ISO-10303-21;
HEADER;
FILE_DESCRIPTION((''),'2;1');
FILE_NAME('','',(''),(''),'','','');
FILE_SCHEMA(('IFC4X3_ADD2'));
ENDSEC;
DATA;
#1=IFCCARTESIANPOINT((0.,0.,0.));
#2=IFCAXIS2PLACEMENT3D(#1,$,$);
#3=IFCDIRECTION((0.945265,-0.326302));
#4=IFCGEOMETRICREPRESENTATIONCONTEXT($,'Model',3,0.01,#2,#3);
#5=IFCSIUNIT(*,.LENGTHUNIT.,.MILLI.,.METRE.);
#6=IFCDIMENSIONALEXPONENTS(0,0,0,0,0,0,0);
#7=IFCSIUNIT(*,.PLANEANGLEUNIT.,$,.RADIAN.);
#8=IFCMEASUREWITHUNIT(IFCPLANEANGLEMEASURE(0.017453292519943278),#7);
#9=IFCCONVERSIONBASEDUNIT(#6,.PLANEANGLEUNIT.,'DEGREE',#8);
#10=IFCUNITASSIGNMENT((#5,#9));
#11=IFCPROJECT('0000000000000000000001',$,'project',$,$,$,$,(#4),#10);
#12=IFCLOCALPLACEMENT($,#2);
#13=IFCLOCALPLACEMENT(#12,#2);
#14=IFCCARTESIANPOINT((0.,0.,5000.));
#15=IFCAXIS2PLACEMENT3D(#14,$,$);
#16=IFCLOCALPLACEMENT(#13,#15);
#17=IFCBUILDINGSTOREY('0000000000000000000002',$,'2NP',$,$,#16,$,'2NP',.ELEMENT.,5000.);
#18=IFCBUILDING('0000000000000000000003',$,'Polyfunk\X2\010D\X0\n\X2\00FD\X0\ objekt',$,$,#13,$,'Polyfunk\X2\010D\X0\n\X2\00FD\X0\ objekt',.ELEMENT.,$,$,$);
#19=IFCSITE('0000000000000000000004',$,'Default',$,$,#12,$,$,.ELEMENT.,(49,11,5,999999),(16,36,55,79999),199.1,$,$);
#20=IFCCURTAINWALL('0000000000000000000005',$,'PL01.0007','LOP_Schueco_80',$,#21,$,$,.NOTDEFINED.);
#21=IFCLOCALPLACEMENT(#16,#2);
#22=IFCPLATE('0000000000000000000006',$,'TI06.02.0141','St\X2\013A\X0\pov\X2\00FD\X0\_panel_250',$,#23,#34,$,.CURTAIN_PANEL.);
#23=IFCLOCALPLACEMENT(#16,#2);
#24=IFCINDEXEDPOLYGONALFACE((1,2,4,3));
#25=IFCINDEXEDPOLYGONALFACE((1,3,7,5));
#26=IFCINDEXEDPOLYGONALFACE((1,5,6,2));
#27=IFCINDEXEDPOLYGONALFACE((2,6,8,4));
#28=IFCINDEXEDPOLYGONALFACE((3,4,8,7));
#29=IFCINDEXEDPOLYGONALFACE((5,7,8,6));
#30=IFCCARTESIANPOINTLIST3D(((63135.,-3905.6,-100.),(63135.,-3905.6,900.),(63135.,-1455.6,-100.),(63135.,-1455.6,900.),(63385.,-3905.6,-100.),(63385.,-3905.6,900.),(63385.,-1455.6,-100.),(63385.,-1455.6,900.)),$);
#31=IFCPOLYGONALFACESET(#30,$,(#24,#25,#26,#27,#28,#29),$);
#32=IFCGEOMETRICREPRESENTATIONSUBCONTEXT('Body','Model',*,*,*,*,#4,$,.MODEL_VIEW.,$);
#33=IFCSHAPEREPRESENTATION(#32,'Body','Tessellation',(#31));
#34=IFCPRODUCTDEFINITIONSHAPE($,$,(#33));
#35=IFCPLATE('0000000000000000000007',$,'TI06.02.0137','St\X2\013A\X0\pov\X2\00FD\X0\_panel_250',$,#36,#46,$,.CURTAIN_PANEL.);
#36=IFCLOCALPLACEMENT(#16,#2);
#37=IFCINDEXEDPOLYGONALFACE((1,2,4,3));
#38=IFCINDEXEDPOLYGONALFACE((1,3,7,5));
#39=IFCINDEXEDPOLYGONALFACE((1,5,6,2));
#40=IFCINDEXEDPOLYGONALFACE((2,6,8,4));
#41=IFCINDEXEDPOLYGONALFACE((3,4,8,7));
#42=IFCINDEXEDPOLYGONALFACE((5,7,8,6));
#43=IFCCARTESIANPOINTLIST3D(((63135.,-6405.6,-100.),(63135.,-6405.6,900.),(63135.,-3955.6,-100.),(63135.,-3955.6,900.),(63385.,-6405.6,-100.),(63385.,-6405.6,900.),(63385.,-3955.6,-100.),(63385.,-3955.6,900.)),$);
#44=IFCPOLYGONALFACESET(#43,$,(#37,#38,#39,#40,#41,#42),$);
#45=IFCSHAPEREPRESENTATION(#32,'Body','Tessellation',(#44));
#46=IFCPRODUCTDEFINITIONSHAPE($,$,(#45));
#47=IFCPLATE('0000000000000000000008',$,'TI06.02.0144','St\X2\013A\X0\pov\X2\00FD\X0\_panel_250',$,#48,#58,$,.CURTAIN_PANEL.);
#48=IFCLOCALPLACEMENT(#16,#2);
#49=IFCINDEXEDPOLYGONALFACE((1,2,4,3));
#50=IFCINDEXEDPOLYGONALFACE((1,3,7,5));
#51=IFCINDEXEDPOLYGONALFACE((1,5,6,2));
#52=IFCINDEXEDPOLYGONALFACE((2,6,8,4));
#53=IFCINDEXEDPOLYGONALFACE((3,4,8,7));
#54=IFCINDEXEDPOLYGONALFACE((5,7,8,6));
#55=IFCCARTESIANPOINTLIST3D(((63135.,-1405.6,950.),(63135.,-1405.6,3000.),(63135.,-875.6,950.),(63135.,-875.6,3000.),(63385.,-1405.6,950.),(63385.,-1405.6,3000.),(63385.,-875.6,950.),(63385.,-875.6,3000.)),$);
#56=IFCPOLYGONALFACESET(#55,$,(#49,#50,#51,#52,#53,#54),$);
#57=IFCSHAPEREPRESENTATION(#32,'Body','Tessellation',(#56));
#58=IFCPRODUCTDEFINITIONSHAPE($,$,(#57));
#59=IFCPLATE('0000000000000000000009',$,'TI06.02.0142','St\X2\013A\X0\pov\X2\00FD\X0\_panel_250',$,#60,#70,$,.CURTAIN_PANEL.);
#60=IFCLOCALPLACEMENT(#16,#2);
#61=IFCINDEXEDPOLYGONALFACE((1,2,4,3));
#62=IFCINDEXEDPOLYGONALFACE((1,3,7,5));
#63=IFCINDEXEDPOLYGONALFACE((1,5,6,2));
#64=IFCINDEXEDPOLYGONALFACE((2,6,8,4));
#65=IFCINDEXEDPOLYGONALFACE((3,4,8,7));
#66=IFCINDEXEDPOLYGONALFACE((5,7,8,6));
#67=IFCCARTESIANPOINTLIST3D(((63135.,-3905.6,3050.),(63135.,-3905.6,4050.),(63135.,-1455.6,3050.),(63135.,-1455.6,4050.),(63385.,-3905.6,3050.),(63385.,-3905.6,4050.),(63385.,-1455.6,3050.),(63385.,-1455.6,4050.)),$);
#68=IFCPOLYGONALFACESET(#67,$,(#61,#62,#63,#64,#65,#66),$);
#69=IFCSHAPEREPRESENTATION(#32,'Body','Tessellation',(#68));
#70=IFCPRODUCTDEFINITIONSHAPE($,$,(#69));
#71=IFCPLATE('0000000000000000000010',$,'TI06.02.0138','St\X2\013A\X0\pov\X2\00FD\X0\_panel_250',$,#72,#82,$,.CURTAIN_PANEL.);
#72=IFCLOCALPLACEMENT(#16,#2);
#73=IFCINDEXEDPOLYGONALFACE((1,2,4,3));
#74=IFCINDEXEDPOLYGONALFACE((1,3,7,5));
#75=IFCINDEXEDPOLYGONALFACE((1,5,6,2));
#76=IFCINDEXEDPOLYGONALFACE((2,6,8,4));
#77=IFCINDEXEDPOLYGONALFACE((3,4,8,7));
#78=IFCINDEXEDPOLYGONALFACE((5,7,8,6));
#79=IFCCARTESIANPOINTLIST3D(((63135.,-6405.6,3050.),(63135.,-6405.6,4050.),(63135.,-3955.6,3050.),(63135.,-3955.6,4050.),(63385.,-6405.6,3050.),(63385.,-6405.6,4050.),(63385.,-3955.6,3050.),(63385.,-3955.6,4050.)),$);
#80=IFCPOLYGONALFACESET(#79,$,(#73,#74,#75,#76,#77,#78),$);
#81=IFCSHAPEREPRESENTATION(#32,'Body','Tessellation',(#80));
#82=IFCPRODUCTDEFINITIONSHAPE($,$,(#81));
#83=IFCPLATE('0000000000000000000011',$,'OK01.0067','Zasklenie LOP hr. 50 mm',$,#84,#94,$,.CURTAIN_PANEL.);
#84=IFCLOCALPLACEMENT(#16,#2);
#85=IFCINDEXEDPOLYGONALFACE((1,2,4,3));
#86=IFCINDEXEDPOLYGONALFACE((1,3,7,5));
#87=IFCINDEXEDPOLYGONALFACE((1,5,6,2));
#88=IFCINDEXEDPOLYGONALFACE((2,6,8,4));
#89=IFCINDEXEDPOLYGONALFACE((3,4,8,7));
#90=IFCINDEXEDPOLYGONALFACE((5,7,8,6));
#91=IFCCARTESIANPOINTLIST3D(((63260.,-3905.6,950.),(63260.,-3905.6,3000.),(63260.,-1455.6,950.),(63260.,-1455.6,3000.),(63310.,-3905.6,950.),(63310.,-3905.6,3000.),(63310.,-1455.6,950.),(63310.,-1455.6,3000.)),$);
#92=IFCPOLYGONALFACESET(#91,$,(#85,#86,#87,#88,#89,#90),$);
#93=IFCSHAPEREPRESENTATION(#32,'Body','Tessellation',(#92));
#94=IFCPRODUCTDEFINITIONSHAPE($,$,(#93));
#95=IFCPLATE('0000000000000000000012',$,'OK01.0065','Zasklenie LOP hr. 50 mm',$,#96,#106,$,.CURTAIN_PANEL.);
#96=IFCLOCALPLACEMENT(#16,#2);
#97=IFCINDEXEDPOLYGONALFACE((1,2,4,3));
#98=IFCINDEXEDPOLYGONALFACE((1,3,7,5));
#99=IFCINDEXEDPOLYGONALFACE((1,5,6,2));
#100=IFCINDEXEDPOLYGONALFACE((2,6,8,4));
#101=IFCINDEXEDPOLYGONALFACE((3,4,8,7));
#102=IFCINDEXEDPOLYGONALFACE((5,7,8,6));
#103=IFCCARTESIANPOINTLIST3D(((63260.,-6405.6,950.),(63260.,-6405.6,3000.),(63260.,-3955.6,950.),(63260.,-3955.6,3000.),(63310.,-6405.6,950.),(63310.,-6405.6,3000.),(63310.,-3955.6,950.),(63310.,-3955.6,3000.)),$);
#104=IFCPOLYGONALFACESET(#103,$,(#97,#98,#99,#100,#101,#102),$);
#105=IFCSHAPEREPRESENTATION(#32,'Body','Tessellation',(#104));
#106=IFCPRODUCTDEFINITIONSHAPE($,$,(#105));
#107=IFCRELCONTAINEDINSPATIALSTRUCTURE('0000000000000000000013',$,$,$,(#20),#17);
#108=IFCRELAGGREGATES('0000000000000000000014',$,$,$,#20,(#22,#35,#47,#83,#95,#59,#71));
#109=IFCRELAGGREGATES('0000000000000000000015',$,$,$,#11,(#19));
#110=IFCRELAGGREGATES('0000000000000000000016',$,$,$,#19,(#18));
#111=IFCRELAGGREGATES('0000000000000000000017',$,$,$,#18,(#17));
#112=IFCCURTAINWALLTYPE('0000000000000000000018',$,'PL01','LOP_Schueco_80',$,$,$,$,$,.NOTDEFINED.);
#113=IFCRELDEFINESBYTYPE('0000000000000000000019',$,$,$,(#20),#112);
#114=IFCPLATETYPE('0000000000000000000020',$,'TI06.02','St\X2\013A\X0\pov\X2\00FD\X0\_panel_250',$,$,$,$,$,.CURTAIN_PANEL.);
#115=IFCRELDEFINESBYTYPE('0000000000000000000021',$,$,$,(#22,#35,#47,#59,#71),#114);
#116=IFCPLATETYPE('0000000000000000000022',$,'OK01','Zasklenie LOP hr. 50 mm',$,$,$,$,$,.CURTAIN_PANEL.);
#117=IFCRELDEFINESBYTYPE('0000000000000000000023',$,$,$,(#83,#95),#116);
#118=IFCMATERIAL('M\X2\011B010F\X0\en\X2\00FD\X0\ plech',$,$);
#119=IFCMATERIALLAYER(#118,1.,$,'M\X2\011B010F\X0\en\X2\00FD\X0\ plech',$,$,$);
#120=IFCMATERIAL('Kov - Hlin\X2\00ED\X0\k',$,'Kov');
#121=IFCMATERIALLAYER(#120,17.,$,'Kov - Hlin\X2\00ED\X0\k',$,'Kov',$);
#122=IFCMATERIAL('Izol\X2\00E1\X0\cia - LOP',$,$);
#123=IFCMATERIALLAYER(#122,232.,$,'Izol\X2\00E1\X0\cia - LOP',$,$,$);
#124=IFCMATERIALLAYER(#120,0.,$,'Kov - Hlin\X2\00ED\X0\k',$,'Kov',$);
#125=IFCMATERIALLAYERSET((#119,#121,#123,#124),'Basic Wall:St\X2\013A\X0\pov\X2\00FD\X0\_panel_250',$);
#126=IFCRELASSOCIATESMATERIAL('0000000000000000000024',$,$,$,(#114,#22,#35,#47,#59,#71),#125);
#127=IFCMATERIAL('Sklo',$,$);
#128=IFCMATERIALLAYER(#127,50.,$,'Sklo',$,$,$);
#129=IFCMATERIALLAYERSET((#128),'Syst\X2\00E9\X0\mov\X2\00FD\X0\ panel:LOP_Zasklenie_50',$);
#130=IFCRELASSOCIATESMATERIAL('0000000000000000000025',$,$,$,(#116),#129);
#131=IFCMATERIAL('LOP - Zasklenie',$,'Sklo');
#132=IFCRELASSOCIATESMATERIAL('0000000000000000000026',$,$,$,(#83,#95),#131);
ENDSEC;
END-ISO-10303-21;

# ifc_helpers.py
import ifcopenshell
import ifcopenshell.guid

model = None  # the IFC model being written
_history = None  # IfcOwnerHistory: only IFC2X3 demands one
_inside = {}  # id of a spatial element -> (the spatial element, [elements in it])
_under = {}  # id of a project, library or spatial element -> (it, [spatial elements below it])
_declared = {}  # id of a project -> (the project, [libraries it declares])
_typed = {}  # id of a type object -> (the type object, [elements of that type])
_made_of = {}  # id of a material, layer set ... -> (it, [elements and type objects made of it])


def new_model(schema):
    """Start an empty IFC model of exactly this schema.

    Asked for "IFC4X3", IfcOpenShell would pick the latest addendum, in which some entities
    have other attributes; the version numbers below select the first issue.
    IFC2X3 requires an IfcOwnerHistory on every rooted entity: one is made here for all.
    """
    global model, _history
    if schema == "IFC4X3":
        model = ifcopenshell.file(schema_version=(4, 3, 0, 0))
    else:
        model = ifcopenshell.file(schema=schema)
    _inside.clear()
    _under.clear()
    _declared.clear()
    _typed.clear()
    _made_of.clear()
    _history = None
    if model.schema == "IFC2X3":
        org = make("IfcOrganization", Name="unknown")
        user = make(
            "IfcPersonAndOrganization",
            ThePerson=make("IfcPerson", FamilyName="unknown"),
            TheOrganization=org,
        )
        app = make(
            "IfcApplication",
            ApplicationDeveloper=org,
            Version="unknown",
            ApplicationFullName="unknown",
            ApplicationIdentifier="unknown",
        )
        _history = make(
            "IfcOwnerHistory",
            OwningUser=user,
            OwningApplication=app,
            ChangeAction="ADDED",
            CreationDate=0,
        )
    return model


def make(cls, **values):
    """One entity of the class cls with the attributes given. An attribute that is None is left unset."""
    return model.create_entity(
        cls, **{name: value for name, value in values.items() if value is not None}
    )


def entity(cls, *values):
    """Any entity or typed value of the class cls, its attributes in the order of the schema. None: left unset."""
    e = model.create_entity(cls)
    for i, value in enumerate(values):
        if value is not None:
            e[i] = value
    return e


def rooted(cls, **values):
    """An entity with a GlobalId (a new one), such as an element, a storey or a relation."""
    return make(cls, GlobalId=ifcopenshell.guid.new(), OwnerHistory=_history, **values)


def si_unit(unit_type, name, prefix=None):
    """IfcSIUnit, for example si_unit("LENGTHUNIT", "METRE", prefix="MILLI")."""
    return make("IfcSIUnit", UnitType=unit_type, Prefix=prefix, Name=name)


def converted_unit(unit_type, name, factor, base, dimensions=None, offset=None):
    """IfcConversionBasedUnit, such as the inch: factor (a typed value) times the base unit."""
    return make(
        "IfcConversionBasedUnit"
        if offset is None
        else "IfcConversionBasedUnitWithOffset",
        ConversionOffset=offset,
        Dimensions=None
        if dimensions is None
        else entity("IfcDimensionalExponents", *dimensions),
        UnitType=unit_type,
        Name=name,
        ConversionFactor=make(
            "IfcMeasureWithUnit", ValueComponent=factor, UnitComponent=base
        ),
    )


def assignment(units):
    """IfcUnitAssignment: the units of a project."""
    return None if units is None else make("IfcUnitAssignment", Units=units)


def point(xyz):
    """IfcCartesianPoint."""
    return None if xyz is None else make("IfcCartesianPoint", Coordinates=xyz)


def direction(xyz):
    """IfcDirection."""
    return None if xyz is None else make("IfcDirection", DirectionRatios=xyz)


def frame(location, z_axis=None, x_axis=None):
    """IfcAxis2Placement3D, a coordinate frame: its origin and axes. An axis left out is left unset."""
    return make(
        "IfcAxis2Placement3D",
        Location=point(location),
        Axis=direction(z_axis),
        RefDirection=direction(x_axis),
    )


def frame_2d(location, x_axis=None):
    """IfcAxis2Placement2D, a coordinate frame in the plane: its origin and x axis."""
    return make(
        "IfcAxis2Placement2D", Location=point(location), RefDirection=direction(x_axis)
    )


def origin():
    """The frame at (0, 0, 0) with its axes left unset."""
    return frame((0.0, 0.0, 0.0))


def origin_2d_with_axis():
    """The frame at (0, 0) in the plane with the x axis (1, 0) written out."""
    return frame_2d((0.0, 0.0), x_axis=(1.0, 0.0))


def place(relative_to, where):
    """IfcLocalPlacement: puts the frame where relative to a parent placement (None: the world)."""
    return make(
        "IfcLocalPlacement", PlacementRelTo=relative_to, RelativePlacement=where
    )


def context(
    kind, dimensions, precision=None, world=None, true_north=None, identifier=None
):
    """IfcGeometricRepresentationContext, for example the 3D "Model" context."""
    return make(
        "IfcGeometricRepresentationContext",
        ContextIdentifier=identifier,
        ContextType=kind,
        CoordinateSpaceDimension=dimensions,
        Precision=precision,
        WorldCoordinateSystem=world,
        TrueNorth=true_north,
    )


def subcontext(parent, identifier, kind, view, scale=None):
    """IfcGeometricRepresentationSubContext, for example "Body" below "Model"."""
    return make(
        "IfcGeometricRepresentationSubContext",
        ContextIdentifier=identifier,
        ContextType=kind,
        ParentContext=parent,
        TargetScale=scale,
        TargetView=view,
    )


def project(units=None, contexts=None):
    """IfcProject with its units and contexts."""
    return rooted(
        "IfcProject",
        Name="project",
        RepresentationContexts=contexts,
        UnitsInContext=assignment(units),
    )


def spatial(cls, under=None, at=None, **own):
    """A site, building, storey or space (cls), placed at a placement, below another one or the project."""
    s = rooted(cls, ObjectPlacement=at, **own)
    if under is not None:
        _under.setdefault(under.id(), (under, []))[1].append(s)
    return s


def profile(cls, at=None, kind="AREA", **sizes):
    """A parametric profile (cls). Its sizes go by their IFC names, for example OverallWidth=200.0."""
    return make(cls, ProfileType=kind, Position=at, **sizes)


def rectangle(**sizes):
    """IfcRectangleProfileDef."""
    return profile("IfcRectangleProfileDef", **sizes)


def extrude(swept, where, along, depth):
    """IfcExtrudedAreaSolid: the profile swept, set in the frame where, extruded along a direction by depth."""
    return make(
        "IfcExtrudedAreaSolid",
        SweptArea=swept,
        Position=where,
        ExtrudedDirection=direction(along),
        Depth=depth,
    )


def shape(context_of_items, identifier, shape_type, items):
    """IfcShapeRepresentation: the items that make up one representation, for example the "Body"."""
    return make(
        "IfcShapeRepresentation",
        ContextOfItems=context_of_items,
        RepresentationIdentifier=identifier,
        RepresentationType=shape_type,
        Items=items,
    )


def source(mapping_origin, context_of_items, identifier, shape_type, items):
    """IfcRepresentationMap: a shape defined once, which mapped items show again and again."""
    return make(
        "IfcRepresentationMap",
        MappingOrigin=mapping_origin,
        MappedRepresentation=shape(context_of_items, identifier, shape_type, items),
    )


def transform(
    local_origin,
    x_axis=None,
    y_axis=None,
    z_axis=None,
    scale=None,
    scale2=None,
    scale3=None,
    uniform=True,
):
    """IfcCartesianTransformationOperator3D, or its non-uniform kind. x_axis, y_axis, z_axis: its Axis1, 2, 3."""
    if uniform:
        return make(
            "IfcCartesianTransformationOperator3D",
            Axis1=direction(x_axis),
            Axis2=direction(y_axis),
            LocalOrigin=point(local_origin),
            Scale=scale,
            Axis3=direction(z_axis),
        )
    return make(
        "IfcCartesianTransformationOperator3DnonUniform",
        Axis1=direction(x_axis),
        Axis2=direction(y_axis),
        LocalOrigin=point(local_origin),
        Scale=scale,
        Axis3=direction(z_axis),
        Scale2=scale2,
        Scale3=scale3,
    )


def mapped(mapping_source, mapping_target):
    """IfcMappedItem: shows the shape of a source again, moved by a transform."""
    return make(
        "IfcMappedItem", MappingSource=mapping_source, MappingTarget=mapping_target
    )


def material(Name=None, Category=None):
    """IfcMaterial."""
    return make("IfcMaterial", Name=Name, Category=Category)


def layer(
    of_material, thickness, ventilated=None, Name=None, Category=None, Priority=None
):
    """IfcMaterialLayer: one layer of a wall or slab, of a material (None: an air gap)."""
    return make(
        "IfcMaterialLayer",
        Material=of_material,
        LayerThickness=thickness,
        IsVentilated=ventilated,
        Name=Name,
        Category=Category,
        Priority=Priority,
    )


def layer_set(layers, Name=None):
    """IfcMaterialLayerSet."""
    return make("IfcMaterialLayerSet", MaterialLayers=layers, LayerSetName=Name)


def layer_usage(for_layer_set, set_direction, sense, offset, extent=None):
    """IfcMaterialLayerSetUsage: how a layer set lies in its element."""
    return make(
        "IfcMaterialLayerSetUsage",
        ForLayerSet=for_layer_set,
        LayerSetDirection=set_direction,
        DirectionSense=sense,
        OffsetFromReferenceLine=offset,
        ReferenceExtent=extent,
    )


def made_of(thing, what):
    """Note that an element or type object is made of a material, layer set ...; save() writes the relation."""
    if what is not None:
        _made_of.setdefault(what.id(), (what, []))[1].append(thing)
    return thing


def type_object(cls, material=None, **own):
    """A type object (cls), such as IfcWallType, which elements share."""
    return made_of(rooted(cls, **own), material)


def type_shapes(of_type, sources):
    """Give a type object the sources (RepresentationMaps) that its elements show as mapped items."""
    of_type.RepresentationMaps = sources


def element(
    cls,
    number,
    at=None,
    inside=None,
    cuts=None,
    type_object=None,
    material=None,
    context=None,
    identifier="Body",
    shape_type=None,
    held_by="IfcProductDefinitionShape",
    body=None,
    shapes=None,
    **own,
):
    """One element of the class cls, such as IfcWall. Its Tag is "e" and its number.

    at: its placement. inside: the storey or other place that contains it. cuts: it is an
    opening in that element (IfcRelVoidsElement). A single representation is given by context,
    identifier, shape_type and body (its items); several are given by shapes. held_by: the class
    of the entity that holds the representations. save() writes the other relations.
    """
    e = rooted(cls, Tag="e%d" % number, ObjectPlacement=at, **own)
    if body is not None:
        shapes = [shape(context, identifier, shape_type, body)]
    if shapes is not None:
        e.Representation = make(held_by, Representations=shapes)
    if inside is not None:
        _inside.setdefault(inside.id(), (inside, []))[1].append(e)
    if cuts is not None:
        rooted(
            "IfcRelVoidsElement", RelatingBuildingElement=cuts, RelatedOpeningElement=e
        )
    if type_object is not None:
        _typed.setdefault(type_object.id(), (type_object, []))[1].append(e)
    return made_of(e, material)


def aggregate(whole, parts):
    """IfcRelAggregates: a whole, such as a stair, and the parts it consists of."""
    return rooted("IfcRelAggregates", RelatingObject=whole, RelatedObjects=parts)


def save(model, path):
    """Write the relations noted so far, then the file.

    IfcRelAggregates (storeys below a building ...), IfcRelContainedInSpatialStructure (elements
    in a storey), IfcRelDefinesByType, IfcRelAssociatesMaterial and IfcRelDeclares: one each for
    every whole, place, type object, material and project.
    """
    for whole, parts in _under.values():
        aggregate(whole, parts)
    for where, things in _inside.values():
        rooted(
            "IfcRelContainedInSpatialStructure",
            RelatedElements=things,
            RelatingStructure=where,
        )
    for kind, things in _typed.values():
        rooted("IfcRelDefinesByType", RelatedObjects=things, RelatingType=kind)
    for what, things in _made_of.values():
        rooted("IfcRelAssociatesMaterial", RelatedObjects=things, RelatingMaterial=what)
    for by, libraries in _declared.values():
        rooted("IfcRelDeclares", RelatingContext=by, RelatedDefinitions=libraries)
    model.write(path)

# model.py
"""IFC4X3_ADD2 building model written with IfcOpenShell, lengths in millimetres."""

from ifc_helpers import new_model, entity, si_unit, converted_unit, direction, frame, frame_2d, origin, origin_2d_with_axis, place, context, subcontext, project, spatial, rectangle, extrude, source, transform, mapped, material, layer, layer_set, layer_usage, type_object, type_shapes, element, aggregate, save


model = new_model("IFC4X3_ADD2")

# Units and contexts
model_context = context("Model", 3, precision=0.01, world=origin(), true_north=direction((0.945265, -0.326302)))
body_context = subcontext(model_context, "Body", "Model", "MODEL_VIEW")
ifc_project = project(units=[si_unit("LENGTHUNIT", "METRE", prefix="MILLI"), converted_unit("PLANEANGLEUNIT", "DEGREE", entity("IfcPlaneAngleMeasure", 0.017453292519943278), si_unit("PLANEANGLEUNIT", "RADIAN"), dimensions=[0, 0, 0, 0, 0, 0, 0])], contexts=[model_context])

# Site, building, storey
site_placement = place(None, origin())
site = spatial("IfcSite", under=ifc_project, at=site_placement, Name="Default", CompositionType="ELEMENT", RefLatitude=(49, 11, 5, 999999), RefLongitude=(16, 36, 55, 79999), RefElevation=199.1)
building_placement = place(site_placement, origin())
building = spatial("IfcBuilding", under=site, at=building_placement, Name="Polyfunkčný objekt", LongName="Polyfunkčný objekt", CompositionType="ELEMENT")
storey_placement = place(building_placement, frame((0.0, 0.0, 5000.0)))
storey = spatial("IfcBuildingStorey", under=building, at=storey_placement, Name="2NP", LongName="2NP", CompositionType="ELEMENT", Elevation=5000.0)

# Curtain wall, plates
curtain_wall_type = type_object("IfcCurtainWallType", Name="PL01", Description="LOP_Schueco_80", PredefinedType="NOTDEFINED")
curtain_wall_placement = place(storey_placement, frame((0.0, 0.0, -5000.0)))
curtain_wall = element("IfcCurtainWall", 1, at=curtain_wall_placement, inside=storey, type_object=curtain_wall_type, Name="PL01.0007", Description="LOP_Schueco_80", PredefinedType="NOTDEFINED")
ifc_material_1 = material(Name="Měďený plech")
ifc_layer_1 = layer(ifc_material_1, 1.0, Name="Měďený plech")
ifc_material_2 = material(Name="Kov - Hliník", Category="Kov")
ifc_layer_2 = layer(ifc_material_2, 17.0, Name="Kov - Hliník", Category="Kov")
ifc_material_3 = material(Name="Izolácia - LOP")
ifc_layer_3 = layer(ifc_material_3, 232.0, Name="Izolácia - LOP")
ifc_layer_4 = layer(ifc_material_2, 0.0, Name="Kov - Hliník", Category="Kov")
ifc_layer_set_1 = layer_set([ifc_layer_1, ifc_layer_2, ifc_layer_3, ifc_layer_4], Name="Basic Wall:Stĺpový_panel_250")
ifc_layer_usage_1 = layer_usage(ifc_layer_set_1, "AXIS2", "NEGATIVE", 125.0)
plate_type_1 = type_object("IfcPlateType", Name="TI06.02", Description="Stĺpový_panel_250", PredefinedType="CURTAIN_PANEL", material=ifc_layer_set_1)
plate_1_placement = place(storey_placement, frame((63260.0, -1455.6, -100.0), z_axis=(0.0, 0.0, 1.0), x_axis=(0.0, -1.0, 0.0)))
plate_1 = element("IfcPlate", 2, at=plate_1_placement, type_object=plate_type_1, material=ifc_layer_usage_1, Name="TI06.02.0141", Description="Stĺpový_panel_250", PredefinedType="CURTAIN_PANEL", context=body_context, shape_type="SweptSolid", body=[
    extrude(rectangle(XDim=250.0, YDim=2450.0, at=frame_2d((0.0, 0.0), x_axis=(1.0, 0.0))), frame((1225.0, 0.0, 0.0), z_axis=(0.0, 0.0, 1.0), x_axis=(0.0, 1.0, 0.0)), (0.0, 0.0, 1.0), 1000.0),
])
ifc_layer_usage_2 = layer_usage(ifc_layer_set_1, "AXIS2", "NEGATIVE", 125.0)
plate_2_placement = place(storey_placement, frame((63260.0, -3955.6, -100.0), z_axis=(0.0, 0.0, 1.0), x_axis=(0.0, -1.0, 0.0)))
plate_2 = element("IfcPlate", 3, at=plate_2_placement, type_object=plate_type_1, material=ifc_layer_usage_2, Name="TI06.02.0137", Description="Stĺpový_panel_250", PredefinedType="CURTAIN_PANEL", context=body_context, shape_type="SweptSolid", body=[
    extrude(rectangle(XDim=250.0, YDim=2450.0, at=frame_2d((0.0, 0.0), x_axis=(1.0, 0.0))), frame((1225.0, 0.0, 0.0), z_axis=(0.0, 0.0, 1.0), x_axis=(0.0, 1.0, 0.0)), (0.0, 0.0, 1.0), 1000.0),
])
ifc_layer_usage_3 = layer_usage(ifc_layer_set_1, "AXIS2", "NEGATIVE", 125.0)
plate_3_placement = place(storey_placement, frame((63260.0, -875.6, 950.0), z_axis=(0.0, 0.0, 1.0), x_axis=(0.0, -1.0, 0.0)))
plate_3 = element("IfcPlate", 4, at=plate_3_placement, type_object=plate_type_1, material=ifc_layer_usage_3, Name="TI06.02.0144", Description="Stĺpový_panel_250", PredefinedType="CURTAIN_PANEL", context=body_context, shape_type="SweptSolid", body=[
    extrude(rectangle(XDim=250.0, YDim=530.0, at=frame_2d((0.0, 0.0), x_axis=(1.0, 0.0))), frame((265.0, 0.0, 0.0), z_axis=(0.0, 0.0, 1.0), x_axis=(0.0, 1.0, 0.0)), (0.0, 0.0, 1.0), 2050.0),
])
ifc_layer_usage_4 = layer_usage(ifc_layer_set_1, "AXIS2", "NEGATIVE", 125.0)
plate_4_placement = place(storey_placement, frame((63260.0, -1455.6, 3050.0), z_axis=(0.0, 0.0, 1.0), x_axis=(0.0, -1.0, 0.0)))
plate_4 = element("IfcPlate", 5, at=plate_4_placement, type_object=plate_type_1, material=ifc_layer_usage_4, Name="TI06.02.0142", Description="Stĺpový_panel_250", PredefinedType="CURTAIN_PANEL", context=body_context, shape_type="SweptSolid", body=[
    extrude(rectangle(XDim=250.0, YDim=2450.0, at=frame_2d((0.0, 0.0), x_axis=(1.0, 0.0))), frame((1225.0, 0.0, 0.0), z_axis=(0.0, 0.0, 1.0), x_axis=(0.0, 1.0, 0.0)), (0.0, 0.0, 1.0), 1000.0),
])
ifc_layer_usage_5 = layer_usage(ifc_layer_set_1, "AXIS2", "NEGATIVE", 125.0)
plate_5_placement = place(storey_placement, frame((63260.0, -3955.6, 3050.0), z_axis=(0.0, 0.0, 1.0), x_axis=(0.0, -1.0, 0.0)))
plate_5 = element("IfcPlate", 6, at=plate_5_placement, type_object=plate_type_1, material=ifc_layer_usage_5, Name="TI06.02.0138", Description="Stĺpový_panel_250", PredefinedType="CURTAIN_PANEL", context=body_context, shape_type="SweptSolid", body=[
    extrude(rectangle(XDim=250.0, YDim=2450.0, at=frame_2d((0.0, 0.0), x_axis=(1.0, 0.0))), frame((1225.0, 0.0, 0.0), z_axis=(0.0, 0.0, 1.0), x_axis=(0.0, 1.0, 0.0)), (0.0, 0.0, 1.0), 1000.0),
])
ifc_material_4 = material(Name="LOP - Zasklenie", Category="Sklo")
ifc_material_5 = material(Name="Sklo")
ifc_layer_5 = layer(ifc_material_5, 50.0, Name="Sklo")
ifc_layer_set_2 = layer_set([ifc_layer_5], Name="Systémový panel:LOP_Zasklenie_50")
plate_type_2 = type_object("IfcPlateType", Name="OK01", Description="Zasklenie LOP hr. 50 mm", PredefinedType="CURTAIN_PANEL", material=ifc_layer_set_2)
shared_shape_1 = source(origin(), body_context, "Body", "SweptSolid", [
    extrude(rectangle(XDim=50.0, YDim=2450.0, at=origin_2d_with_axis()), frame((0.0, 25.0, 0.0), z_axis=(0.0, 0.0, 1.0), x_axis=(0.0, 1.0, 0.0)), (0.0, 0.0, 1.0), 2050.0),
])
type_shapes(plate_type_2, [shared_shape_1])
plate_6_placement = place(curtain_wall_placement, frame((63260.0, -2680.6, 5950.0), z_axis=(0.0, 0.0, 1.0), x_axis=(0.0, -1.0, 0.0)))
plate_6 = element("IfcPlate", 7, at=plate_6_placement, type_object=plate_type_2, material=ifc_material_4, Name="OK01.0067", Description="Zasklenie LOP hr. 50 mm", PredefinedType="CURTAIN_PANEL", context=body_context, shape_type="MappedRepresentation", body=[
    mapped(shared_shape_1, transform((0.0, 0.0, 0.0), scale=1.0)),
])
plate_7_placement = place(curtain_wall_placement, frame((63260.0, -5180.6, 5950.0), z_axis=(0.0, 0.0, 1.0), x_axis=(0.0, -1.0, 0.0)))
plate_7 = element("IfcPlate", 8, at=plate_7_placement, type_object=plate_type_2, material=ifc_material_4, Name="OK01.0065", Description="Zasklenie LOP hr. 50 mm", PredefinedType="CURTAIN_PANEL", context=body_context, shape_type="MappedRepresentation", body=[
    mapped(shared_shape_1, transform((0.0, 0.0, 0.0), scale=1.0)),
])
aggregate(curtain_wall, [plate_1, plate_2, plate_3, plate_6, plate_7, plate_4, plate_5])

save(model, "model.ifc")
